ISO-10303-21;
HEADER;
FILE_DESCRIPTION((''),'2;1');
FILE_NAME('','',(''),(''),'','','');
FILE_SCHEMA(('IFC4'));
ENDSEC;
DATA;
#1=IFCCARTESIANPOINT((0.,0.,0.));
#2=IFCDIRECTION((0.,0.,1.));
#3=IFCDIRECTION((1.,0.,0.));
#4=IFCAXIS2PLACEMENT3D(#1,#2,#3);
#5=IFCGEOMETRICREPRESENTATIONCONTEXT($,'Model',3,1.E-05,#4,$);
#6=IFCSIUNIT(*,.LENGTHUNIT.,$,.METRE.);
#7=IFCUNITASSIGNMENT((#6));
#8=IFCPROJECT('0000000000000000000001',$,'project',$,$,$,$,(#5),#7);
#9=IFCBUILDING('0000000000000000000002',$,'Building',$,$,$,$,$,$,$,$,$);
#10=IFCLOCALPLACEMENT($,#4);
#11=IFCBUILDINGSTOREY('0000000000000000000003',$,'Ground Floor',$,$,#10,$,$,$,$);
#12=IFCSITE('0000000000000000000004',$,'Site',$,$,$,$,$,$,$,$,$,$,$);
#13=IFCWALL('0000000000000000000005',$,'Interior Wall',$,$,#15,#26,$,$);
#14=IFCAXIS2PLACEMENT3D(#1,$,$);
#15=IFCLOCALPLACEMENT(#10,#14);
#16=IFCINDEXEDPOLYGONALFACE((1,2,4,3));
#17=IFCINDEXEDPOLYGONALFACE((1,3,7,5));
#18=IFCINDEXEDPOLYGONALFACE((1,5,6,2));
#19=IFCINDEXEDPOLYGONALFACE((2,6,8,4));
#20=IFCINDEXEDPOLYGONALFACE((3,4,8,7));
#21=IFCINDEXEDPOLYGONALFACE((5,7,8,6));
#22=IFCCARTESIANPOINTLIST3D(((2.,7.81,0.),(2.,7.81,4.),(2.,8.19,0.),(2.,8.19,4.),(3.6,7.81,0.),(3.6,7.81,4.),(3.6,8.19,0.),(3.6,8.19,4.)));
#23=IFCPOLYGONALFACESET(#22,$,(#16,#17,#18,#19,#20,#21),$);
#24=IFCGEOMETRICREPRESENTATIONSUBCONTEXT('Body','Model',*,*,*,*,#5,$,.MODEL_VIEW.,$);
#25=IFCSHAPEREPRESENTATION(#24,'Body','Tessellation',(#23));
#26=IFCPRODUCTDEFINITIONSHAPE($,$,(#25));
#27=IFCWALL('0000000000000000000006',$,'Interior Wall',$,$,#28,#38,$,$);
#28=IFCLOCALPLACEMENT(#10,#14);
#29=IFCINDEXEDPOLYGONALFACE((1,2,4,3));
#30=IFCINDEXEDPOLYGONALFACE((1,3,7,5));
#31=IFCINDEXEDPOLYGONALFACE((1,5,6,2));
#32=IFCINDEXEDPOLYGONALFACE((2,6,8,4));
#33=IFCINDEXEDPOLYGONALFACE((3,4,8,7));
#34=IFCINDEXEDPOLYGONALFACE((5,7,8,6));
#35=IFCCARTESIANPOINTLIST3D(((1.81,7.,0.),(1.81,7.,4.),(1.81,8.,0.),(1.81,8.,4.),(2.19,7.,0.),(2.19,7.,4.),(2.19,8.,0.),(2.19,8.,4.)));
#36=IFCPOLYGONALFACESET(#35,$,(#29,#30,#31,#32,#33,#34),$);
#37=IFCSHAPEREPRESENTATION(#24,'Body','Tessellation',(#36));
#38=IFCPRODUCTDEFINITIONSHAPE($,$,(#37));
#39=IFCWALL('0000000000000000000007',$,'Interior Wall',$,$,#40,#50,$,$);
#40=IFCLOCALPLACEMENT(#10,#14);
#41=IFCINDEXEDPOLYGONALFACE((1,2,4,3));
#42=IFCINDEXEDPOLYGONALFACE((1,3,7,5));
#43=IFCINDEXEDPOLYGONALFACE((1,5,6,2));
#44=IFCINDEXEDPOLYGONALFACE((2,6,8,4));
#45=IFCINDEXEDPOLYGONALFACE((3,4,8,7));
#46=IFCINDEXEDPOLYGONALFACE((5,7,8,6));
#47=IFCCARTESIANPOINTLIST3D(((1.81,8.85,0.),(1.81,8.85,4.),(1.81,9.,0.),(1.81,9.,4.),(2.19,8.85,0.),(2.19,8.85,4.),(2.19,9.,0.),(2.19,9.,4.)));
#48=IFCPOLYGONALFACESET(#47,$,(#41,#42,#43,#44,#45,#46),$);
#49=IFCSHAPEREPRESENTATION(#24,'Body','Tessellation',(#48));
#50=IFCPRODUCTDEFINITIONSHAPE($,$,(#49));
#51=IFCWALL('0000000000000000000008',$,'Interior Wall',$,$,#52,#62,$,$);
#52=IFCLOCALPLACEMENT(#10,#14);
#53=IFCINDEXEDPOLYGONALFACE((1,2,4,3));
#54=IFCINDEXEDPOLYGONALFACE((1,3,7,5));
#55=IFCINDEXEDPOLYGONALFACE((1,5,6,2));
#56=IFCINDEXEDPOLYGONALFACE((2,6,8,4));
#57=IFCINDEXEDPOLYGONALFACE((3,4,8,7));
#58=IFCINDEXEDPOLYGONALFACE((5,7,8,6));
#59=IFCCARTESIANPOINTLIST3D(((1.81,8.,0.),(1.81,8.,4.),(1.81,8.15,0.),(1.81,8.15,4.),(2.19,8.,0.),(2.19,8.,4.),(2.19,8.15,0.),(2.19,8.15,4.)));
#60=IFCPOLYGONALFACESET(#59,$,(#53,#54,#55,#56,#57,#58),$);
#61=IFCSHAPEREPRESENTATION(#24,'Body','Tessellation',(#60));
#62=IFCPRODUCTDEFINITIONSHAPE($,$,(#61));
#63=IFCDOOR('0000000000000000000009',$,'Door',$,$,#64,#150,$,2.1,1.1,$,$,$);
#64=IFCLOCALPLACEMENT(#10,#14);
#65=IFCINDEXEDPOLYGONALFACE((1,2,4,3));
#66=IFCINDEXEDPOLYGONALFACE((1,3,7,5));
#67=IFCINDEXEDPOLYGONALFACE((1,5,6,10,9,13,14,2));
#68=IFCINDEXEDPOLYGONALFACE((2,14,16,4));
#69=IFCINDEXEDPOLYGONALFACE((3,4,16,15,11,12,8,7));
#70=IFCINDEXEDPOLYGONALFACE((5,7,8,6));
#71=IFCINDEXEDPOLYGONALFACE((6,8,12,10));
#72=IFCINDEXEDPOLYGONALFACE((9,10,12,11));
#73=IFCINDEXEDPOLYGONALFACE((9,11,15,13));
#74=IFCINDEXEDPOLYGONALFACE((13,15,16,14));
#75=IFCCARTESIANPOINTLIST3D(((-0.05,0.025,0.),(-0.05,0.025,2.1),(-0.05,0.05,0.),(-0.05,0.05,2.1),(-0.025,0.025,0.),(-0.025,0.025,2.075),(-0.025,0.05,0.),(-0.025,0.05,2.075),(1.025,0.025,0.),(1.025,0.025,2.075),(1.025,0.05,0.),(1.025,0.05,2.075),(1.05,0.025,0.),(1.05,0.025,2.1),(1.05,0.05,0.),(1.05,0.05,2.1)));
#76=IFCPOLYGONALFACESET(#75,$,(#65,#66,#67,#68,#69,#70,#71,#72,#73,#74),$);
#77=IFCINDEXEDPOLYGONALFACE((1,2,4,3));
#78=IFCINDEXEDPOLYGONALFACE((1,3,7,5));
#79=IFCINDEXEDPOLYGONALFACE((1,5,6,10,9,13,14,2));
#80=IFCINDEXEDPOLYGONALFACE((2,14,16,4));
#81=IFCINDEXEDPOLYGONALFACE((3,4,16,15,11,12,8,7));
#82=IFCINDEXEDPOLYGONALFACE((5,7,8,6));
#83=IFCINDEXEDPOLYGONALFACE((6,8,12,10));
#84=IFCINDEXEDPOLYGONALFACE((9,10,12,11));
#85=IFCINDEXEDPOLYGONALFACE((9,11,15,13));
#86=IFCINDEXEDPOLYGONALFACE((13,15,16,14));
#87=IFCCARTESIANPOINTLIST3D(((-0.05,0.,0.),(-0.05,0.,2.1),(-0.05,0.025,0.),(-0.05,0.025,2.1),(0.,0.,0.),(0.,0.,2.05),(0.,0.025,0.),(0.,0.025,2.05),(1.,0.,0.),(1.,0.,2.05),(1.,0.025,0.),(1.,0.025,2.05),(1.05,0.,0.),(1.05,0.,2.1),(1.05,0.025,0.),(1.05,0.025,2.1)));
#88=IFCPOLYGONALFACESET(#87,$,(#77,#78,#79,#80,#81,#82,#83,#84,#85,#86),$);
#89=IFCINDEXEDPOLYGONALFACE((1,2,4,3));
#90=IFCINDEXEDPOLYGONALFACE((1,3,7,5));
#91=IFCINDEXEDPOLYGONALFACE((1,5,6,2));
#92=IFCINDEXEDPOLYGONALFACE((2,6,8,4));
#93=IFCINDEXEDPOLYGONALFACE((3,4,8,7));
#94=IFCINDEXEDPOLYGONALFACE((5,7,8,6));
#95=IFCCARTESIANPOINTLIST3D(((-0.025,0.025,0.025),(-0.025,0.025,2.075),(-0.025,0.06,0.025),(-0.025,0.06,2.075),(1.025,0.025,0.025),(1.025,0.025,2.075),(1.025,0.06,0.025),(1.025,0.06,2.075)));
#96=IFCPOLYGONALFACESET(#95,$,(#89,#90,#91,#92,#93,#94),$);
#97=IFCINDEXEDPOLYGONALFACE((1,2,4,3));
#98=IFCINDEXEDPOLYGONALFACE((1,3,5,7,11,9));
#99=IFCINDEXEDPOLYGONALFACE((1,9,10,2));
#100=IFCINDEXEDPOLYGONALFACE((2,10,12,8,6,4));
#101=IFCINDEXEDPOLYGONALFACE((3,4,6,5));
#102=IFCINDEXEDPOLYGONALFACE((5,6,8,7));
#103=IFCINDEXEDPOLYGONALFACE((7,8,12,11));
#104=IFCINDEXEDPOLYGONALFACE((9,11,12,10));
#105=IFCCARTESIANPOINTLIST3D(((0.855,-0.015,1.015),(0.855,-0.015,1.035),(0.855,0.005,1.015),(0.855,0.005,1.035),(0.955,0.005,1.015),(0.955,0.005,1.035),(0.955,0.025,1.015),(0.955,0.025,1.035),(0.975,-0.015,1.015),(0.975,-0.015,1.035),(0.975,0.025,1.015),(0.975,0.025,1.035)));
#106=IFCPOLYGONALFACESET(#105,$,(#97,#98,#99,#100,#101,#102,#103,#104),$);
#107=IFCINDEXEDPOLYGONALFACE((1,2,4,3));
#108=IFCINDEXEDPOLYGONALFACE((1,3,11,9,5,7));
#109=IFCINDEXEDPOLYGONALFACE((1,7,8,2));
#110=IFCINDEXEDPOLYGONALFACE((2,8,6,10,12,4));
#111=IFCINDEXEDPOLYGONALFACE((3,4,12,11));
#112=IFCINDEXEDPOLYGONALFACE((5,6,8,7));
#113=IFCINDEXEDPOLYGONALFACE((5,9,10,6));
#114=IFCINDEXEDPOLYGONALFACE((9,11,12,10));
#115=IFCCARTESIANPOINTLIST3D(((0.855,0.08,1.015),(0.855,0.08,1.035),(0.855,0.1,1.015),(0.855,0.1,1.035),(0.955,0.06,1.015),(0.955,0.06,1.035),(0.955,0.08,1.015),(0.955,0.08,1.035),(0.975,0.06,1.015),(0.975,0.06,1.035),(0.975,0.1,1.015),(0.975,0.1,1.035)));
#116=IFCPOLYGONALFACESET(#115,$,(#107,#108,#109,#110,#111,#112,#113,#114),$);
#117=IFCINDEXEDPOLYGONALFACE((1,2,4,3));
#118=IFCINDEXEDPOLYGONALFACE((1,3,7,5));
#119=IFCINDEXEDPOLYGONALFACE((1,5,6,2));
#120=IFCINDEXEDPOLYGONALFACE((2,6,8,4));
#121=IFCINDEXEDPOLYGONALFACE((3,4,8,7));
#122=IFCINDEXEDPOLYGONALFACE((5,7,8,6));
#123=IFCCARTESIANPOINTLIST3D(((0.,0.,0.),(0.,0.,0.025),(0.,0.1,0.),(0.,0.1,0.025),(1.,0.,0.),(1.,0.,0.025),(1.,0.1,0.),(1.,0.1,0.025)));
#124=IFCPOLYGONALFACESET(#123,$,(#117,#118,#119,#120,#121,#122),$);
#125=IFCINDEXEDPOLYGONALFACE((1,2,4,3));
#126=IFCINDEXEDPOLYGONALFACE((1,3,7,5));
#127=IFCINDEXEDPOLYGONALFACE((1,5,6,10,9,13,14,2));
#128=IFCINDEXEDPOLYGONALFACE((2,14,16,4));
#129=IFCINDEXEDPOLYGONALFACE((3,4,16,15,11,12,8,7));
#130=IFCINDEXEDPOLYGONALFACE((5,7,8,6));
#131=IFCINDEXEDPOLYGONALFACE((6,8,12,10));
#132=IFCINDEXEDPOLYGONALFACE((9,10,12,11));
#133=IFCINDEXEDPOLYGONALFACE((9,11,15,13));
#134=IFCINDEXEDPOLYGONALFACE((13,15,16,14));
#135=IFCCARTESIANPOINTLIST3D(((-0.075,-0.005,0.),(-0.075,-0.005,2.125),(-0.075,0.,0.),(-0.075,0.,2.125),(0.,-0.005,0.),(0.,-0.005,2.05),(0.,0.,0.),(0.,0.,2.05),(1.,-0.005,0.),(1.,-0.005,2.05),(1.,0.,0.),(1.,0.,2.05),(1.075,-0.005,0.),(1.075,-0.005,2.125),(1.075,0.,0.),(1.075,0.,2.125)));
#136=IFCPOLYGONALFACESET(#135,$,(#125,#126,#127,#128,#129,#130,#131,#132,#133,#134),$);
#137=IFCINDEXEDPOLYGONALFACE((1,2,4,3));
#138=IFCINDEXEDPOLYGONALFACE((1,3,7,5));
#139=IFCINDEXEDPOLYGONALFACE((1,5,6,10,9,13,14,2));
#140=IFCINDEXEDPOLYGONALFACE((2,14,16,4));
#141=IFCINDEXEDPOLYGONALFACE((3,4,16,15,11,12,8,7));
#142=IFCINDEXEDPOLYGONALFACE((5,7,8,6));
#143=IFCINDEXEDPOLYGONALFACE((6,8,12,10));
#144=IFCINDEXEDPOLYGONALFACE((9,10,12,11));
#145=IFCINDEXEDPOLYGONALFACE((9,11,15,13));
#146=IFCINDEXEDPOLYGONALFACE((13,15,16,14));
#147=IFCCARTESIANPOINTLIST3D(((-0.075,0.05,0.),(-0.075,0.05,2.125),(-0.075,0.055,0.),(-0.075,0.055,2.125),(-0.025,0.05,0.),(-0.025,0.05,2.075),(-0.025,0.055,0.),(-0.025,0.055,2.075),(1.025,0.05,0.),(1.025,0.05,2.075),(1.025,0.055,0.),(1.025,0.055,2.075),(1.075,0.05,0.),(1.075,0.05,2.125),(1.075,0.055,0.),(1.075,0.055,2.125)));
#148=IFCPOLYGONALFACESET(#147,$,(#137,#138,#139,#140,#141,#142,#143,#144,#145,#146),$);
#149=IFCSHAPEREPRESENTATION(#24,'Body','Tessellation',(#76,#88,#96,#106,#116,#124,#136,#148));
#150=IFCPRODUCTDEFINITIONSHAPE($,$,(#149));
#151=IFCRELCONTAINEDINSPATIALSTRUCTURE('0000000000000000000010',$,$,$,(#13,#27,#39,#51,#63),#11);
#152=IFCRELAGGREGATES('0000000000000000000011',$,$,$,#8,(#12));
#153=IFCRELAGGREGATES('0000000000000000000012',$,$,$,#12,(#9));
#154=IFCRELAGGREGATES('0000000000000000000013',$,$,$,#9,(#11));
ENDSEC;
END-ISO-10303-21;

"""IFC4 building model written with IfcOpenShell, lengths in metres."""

from ifc_helpers import new_model, si_unit, frame, origin_with_axes, place, context, subcontext, project, spatial, line, indexed_curve, outline, extrude, element, save


model = new_model("IFC4")

# Units and contexts
model_context = context("Model", 3, precision=1e-05, world=origin_with_axes())
body_context = subcontext(model_context, "Body", "Model", "MODEL_VIEW")
ifc_project = project(units=[si_unit("LENGTHUNIT", "METRE")], contexts=[model_context])

# Site, building, storey
site = spatial("IfcSite", under=ifc_project, Name="Site")
building = spatial("IfcBuilding", under=site, Name="Building")
storey_placement = place(None, origin_with_axes())
storey = spatial("IfcBuildingStorey", under=building, at=storey_placement, Name="Ground Floor")

# Walls
wall_1_placement = place(storey_placement, frame((3.6, 8.0, 0.0), z_axis=(0.0, 0.0, 1.0), x_axis=(-1.0, 0.0, 0.0)))
element("IfcWall", 1, at=wall_1_placement, inside=storey, Name="Interior Wall", context=body_context, shape_type="SweptSolid", body=[
    extrude(outline(indexed_curve([(0.0, 0.0), (0.0, 0.38), (1.6, 0.38), (1.6, 0.0), (0.0, 0.0)], self_intersect=False)), frame((0.0, -0.19, 0.0), z_axis=(0.0, 0.0, 1.0), x_axis=(1.0, 0.0, 0.0)), (0.0, 0.0, 1.0), 4.0),
])
wall_2_placement = place(storey_placement, frame((2.0, 8.0, 0.0), z_axis=(0.0, 0.0, 1.0), x_axis=(0.0, -1.0, 0.0)))
element("IfcWall", 2, at=wall_2_placement, inside=storey, Name="Interior Wall", context=body_context, shape_type="SweptSolid", body=[
    extrude(outline(indexed_curve([(0.0, 0.0), (0.0, 0.38), (1.0, 0.38), (1.0, 0.0), (0.0, 0.0)], self_intersect=False)), frame((0.0, -0.19, 0.0), z_axis=(0.0, 0.0, 1.0), x_axis=(1.0, 0.0, 0.0)), (0.0, 0.0, 1.0), 4.0),
])
for number, where, z_axis, x_axis, name in (
    (3, (2.0, 9.0, 0.0), (0.0, 0.0, 1.0), (0.0, -1.0, 0.0), "Interior Wall"),
    (4, (2.0, 8.15, 0.0), (0.0, 0.0, 1.0), (0.0, -1.0, 0.0), "Interior Wall"),
):
    element("IfcWall", number, at=place(storey_placement, frame(where, z_axis=z_axis, x_axis=x_axis)), inside=storey, Name=name, context=body_context, shape_type="SweptSolid", body=[
        extrude(outline(indexed_curve([(0.0, 0.0), (0.0, 0.38), (0.15, 0.38), (0.15, 0.0), (0.0, 0.0)], self_intersect=False)), frame((0.0, -0.19, 0.0), z_axis=(0.0, 0.0, 1.0), x_axis=(1.0, 0.0, 0.0)), (0.0, 0.0, 1.0), 4.0),
    ])

# Door
door_1_placement = place(storey_placement, frame((-0.05, 0.0, 0.0), z_axis=(0.0, 0.0, 1.0), x_axis=(1.0, 0.0, 0.0)))
element("IfcDoor", 5, at=door_1_placement, inside=storey, Name="Door", OverallHeight=2.1, OverallWidth=1.1, context=body_context, shape_type="SweptSolid", body=[
    extrude(outline(indexed_curve([(0.0, 0.0), (0.0, 2.1), (1.1, 2.1), (1.1, 0.0), (1.075, 0.0), (1.075, 2.075), (0.025, 2.075), (0.025, 0.0)], segments=[line(1, 2, 3, 4, 5, 6, 7, 8, 1)])), frame((0.0, 0.025, 0.0), z_axis=(0.0, -1.0, 0.0), x_axis=(1.0, 0.0, 0.0)), (0.0, 0.0, -1.0), 0.025),
    extrude(outline(indexed_curve([(0.0, 0.0), (0.0, 2.1), (1.1, 2.1), (1.1, 0.0), (1.05, 0.0), (1.05, 2.05), (0.05, 2.05), (0.05, 0.0)], segments=[line(1, 2, 3, 4, 5, 6, 7, 8, 1)])), frame((0.0, 0.0, 0.0), z_axis=(0.0, -1.0, 0.0), x_axis=(1.0, 0.0, 0.0)), (0.0, 0.0, -1.0), 0.025),
    extrude(outline(indexed_curve([(0.0, 0.0), (1.05, 0.0), (1.05, 0.035), (0.0, 0.035)], segments=[line(1, 2, 3, 4, 1)])), frame((0.025, 0.025, 0.025), z_axis=(0.0, 0.0, 1.0), x_axis=(1.0, 0.0, 0.0)), (0.0, 0.0, 1.0), 2.05),
    extrude(outline(indexed_curve([(0.0, 0.0), (0.0, -0.04), (-0.12, -0.04), (-0.12, -0.02), (-0.02, -0.02), (-0.02, 0.0)], segments=[line(1, 2, 3, 4, 5, 6, 1)])), frame((1.025, 0.025, 1.015), z_axis=(0.0, 0.0, 1.0), x_axis=(1.0, 0.0, 0.0)), (0.0, 0.0, 1.0), 0.02),
    extrude(outline(indexed_curve([(0.0, 0.0), (0.0, 0.04), (-0.12, 0.04), (-0.12, 0.02), (-0.02, 0.02), (-0.02, 0.0)], segments=[line(1, 2, 3, 4, 5, 6, 1)])), frame((1.025, 0.06, 1.015), z_axis=(0.0, 0.0, 1.0), x_axis=(1.0, 0.0, 0.0)), (0.0, 0.0, 1.0), 0.02),
    extrude(outline(indexed_curve([(0.0, 0.0), (1.0, 0.0), (1.0, 0.1), (0.0, 0.1)], segments=[line(1, 2, 3, 4, 1)])), frame((0.05, 0.0, 0.0), z_axis=(0.0, 0.0, 1.0), x_axis=(1.0, 0.0, 0.0)), (0.0, 0.0, 1.0), 0.025),
    extrude(outline(indexed_curve([(0.0, 0.0), (0.0, 2.125), (1.15, 2.125), (1.15, 0.0), (1.075, 0.0), (1.075, 2.05), (0.075, 2.05), (0.075, 0.0)], segments=[line(1, 2, 3, 4, 5, 6, 7, 8, 1)])), frame((-0.025, -0.005, 0.0), z_axis=(0.0, -1.0, 0.0), x_axis=(1.0, 0.0, 0.0)), (0.0, 0.0, -1.0), 0.005),
    extrude(outline(indexed_curve([(0.0, 0.0), (0.0, 2.125), (1.15, 2.125), (1.15, 0.0), (1.1, 0.0), (1.1, 2.075), (0.05, 2.075), (0.05, 0.0)], segments=[line(1, 2, 3, 4, 5, 6, 7, 8, 1)])), frame((-0.025, 0.05, 0.0), z_axis=(0.0, -1.0, 0.0), x_axis=(1.0, 0.0, 0.0)), (0.0, 0.0, -1.0), 0.005),
])

save(model, "model.ifc")
